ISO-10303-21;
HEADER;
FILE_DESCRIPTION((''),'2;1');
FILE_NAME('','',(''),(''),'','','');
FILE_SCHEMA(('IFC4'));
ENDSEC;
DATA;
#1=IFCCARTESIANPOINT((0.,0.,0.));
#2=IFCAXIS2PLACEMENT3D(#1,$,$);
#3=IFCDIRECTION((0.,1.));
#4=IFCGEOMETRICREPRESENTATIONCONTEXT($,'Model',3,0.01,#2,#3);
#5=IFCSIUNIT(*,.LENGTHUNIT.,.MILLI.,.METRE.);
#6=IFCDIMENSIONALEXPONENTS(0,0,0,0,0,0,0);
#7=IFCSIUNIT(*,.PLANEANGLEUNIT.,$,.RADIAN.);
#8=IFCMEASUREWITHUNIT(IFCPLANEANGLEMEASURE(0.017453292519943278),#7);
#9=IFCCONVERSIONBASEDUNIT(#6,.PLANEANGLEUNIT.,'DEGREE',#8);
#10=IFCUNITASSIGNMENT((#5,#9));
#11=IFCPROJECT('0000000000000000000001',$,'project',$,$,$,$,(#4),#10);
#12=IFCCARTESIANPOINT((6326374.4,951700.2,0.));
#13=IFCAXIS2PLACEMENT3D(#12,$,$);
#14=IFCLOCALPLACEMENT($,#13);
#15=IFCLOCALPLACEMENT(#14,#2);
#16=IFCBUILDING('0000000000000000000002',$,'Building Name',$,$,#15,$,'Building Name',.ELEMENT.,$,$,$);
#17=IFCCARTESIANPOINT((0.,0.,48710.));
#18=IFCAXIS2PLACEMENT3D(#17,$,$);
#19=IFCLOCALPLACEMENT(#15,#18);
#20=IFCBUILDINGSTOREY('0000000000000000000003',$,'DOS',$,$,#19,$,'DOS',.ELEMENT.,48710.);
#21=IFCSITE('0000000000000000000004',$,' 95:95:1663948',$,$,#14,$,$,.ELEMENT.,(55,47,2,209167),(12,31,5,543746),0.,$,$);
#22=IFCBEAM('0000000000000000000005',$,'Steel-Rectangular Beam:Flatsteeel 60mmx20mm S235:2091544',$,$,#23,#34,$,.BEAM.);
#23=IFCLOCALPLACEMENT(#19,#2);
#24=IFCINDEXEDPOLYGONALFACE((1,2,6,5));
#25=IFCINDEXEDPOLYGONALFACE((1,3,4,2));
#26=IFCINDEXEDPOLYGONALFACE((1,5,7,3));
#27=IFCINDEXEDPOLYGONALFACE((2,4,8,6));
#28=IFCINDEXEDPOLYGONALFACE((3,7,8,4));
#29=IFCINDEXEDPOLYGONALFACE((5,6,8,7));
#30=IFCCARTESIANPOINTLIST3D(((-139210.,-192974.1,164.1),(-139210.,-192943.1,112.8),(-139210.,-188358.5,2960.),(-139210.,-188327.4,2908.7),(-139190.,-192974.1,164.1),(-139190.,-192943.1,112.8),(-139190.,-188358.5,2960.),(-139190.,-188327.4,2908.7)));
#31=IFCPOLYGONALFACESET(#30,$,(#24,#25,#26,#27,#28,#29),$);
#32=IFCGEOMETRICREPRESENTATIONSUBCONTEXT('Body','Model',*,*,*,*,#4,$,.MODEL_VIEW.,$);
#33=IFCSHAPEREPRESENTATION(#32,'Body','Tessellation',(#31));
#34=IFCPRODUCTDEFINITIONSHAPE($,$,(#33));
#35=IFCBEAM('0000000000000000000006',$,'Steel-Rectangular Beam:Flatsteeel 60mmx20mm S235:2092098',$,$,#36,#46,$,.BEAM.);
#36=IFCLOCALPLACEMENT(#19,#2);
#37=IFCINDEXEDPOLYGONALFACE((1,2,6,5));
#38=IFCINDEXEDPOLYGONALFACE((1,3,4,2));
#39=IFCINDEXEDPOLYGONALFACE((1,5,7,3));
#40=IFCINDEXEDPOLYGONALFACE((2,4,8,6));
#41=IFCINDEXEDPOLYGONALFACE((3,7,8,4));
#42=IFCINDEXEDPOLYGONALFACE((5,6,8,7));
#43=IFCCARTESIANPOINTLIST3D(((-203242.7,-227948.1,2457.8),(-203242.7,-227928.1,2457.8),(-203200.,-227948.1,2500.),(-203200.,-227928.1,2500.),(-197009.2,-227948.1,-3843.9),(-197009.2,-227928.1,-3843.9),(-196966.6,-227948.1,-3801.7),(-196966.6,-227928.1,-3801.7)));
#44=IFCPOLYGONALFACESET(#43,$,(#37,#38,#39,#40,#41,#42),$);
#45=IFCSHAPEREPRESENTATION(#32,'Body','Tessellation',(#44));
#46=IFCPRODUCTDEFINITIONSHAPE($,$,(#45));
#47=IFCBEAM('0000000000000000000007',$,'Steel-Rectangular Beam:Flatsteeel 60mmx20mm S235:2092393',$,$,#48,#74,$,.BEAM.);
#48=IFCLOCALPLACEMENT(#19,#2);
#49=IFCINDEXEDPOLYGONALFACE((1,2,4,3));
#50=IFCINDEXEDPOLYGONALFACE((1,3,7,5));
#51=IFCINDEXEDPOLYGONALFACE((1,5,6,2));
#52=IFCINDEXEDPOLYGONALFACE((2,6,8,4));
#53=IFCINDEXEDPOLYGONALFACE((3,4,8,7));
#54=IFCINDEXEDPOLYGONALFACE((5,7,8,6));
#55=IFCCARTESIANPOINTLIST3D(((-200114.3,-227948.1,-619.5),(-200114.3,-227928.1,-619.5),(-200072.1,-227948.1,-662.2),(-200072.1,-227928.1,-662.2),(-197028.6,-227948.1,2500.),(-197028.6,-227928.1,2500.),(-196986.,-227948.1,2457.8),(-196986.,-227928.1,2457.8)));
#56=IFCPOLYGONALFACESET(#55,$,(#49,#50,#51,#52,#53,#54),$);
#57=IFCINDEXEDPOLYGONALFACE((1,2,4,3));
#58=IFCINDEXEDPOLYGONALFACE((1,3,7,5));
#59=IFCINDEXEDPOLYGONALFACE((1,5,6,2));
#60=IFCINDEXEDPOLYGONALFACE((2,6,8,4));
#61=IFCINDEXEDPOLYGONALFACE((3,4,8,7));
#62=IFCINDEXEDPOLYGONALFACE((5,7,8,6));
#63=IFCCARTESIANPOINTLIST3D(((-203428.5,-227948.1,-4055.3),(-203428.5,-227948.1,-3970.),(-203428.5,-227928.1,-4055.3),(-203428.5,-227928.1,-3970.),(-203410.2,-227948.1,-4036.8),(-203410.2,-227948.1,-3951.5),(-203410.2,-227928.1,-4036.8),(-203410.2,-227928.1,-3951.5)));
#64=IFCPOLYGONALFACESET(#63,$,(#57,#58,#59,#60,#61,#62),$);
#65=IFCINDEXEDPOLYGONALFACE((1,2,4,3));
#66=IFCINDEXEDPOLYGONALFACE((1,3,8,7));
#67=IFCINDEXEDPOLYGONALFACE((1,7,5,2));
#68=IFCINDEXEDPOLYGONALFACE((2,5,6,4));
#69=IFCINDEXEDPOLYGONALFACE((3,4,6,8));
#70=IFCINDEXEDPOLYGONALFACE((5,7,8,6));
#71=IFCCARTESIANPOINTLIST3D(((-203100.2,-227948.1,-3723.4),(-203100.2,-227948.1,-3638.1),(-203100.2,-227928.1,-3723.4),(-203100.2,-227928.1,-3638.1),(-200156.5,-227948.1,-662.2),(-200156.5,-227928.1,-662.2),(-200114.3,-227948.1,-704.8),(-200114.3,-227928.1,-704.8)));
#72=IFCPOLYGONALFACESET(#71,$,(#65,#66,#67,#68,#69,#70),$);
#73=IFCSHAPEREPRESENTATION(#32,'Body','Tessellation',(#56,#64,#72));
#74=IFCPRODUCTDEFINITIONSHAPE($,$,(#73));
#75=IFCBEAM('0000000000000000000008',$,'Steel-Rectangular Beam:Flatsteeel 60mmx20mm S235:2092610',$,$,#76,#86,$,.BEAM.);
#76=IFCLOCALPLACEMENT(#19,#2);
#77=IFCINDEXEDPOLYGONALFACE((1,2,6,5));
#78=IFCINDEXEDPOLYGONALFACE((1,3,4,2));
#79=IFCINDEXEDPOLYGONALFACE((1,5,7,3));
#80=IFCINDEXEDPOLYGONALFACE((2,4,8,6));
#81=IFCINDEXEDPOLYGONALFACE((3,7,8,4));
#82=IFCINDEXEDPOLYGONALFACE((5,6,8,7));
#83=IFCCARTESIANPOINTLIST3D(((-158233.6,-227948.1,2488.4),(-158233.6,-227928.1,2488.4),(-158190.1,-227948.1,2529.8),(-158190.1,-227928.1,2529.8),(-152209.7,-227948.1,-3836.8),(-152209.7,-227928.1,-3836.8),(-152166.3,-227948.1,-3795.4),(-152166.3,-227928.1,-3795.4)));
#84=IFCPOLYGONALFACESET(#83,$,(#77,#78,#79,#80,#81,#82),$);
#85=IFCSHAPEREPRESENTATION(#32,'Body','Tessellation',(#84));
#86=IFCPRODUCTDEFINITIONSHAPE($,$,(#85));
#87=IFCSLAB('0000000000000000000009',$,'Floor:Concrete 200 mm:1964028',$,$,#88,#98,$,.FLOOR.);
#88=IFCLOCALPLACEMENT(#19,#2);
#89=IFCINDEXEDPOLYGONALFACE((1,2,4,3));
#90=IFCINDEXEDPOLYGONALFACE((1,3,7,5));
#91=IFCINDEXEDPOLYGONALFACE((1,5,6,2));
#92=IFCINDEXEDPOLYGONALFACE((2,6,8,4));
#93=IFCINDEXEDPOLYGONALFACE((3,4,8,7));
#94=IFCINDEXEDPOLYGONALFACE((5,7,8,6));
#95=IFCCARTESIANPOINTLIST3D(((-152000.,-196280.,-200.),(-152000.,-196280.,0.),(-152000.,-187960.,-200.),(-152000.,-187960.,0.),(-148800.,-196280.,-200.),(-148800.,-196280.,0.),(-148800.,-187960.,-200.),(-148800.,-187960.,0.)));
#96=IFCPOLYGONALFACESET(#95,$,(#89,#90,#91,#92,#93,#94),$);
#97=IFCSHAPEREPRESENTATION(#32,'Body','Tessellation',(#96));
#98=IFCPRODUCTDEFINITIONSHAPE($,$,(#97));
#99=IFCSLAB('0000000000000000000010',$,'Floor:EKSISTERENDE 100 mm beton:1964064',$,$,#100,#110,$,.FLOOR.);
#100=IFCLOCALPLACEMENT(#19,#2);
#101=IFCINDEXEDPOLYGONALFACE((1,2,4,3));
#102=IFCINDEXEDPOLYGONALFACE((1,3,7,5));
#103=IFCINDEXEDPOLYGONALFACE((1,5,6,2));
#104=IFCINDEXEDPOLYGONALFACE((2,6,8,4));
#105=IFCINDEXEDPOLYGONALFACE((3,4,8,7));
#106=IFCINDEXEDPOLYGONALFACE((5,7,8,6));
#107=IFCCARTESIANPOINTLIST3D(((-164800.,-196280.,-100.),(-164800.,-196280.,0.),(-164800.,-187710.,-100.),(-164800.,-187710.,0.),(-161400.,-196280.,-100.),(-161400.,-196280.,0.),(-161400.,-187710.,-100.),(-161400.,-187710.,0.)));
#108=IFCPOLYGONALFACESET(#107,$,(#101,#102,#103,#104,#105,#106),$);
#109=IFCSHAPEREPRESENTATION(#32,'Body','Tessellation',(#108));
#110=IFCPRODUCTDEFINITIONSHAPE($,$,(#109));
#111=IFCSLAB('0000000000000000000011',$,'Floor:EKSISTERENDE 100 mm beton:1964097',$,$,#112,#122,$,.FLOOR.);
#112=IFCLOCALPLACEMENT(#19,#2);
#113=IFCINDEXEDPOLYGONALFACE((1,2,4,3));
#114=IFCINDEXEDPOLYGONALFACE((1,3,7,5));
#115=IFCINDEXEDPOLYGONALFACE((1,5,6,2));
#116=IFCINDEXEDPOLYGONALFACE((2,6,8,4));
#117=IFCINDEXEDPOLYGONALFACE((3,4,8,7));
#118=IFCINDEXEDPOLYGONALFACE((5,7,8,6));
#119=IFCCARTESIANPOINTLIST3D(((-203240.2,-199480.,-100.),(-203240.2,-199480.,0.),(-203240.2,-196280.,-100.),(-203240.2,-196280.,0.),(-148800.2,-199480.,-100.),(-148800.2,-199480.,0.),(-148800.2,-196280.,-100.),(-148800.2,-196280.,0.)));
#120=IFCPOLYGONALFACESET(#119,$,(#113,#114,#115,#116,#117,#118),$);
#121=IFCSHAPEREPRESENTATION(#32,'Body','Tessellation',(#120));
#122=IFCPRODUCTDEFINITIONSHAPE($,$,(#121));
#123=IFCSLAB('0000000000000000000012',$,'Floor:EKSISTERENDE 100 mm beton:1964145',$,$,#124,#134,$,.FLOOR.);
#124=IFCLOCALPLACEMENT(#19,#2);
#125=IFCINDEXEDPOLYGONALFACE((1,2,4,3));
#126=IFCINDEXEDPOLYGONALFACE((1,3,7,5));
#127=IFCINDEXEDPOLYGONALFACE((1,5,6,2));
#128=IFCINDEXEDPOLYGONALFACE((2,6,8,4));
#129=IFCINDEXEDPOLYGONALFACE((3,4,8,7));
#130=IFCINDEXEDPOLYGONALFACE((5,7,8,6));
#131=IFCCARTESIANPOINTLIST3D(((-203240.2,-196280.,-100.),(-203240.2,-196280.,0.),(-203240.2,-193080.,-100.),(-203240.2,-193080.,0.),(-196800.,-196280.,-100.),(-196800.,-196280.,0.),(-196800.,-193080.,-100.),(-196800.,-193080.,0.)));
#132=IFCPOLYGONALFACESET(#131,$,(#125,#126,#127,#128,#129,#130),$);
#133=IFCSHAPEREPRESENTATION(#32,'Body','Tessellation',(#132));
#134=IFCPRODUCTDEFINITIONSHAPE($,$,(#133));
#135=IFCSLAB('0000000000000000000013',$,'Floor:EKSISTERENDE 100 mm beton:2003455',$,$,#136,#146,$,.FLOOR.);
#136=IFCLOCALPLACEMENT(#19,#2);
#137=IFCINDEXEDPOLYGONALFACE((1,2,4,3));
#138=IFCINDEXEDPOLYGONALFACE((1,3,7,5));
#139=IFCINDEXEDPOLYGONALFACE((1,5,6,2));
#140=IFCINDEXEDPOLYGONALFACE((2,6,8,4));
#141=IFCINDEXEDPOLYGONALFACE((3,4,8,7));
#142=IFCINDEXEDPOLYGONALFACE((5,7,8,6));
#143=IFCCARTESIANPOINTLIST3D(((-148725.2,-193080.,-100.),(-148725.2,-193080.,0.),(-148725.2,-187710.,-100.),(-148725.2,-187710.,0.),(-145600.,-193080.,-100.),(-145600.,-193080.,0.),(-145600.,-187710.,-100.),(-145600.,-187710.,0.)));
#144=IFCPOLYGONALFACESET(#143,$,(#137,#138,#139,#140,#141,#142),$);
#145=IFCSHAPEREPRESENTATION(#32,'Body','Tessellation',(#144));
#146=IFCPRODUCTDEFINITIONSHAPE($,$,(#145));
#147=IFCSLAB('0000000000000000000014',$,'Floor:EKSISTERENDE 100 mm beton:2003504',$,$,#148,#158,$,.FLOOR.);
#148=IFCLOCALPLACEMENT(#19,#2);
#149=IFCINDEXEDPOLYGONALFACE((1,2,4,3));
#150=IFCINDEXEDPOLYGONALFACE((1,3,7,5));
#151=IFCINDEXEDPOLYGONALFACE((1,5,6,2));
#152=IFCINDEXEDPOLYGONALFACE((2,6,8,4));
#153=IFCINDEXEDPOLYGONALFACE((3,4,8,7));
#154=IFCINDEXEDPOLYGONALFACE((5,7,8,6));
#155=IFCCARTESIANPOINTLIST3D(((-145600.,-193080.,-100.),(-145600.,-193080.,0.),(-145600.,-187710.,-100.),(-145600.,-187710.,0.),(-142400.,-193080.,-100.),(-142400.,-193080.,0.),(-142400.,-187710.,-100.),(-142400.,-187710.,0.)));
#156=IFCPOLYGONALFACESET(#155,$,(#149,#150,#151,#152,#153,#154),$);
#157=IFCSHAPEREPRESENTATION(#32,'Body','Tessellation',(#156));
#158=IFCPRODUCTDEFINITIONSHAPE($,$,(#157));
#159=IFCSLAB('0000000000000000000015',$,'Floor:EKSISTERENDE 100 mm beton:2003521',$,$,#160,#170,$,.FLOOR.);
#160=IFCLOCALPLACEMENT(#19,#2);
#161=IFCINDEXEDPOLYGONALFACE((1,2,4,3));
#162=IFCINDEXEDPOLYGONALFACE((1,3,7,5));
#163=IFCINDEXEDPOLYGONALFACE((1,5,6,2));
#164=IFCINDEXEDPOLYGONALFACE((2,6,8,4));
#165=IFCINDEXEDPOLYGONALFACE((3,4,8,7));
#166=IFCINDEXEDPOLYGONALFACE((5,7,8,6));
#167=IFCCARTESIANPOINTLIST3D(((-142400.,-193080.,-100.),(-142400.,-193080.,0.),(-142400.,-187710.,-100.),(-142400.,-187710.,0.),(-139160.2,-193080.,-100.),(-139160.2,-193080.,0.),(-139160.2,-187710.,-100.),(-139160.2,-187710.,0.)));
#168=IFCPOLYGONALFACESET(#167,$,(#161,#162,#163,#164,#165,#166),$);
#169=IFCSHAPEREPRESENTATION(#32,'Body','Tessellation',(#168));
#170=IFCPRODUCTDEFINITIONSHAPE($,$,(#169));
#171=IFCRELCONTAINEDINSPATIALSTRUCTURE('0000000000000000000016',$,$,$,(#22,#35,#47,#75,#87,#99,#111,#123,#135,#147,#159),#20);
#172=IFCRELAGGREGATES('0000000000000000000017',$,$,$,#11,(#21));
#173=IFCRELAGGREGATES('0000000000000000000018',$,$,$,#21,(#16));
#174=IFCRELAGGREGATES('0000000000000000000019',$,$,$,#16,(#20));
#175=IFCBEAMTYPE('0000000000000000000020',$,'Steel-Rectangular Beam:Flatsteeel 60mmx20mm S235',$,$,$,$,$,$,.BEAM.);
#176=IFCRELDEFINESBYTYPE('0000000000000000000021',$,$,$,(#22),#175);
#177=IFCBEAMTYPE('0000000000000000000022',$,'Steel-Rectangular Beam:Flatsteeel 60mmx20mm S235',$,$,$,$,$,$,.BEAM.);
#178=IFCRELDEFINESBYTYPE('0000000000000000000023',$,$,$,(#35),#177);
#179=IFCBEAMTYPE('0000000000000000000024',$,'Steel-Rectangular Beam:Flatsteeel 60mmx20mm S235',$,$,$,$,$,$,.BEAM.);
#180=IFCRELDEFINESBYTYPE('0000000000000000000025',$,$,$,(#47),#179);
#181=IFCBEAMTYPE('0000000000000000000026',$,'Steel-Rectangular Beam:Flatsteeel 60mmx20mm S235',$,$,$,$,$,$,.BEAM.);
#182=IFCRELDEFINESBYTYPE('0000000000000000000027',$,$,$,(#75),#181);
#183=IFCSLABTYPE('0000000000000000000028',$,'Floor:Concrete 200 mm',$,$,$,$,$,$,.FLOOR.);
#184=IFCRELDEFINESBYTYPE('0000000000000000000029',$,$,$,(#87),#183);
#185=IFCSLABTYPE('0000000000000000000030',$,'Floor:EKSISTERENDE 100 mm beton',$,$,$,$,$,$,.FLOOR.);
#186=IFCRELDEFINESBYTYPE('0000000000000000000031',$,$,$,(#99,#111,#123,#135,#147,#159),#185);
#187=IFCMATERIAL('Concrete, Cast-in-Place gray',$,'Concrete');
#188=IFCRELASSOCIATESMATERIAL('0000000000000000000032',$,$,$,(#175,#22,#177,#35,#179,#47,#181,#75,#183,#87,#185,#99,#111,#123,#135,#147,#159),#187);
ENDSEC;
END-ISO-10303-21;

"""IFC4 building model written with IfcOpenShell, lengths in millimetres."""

from ifc_helpers import new_model, entity, si_unit, converted_unit, direction, frame, origin, place, context, subcontext, project, spatial, indexed_curve, outline, extrude, source, transform, mapped, material, type_object, type_shapes, element, save


model = new_model("IFC4")

# Units and contexts
model_context = context("Model", 3, precision=0.01, world=origin(), true_north=direction((0.0, 1.0)))
body_context = subcontext(model_context, "Body", "Model", "MODEL_VIEW")
ifc_project = project(units=[si_unit("LENGTHUNIT", "METRE", prefix="MILLI"), converted_unit("PLANEANGLEUNIT", "DEGREE", entity("IfcPlaneAngleMeasure", 0.017453292519943278), si_unit("PLANEANGLEUNIT", "RADIAN"), dimensions=[0, 0, 0, 0, 0, 0, 0])], contexts=[model_context])

# Site, building, storey
site_placement = place(None, frame((6326374.4, 951700.2, 0.0)))
site = spatial("IfcSite", under=ifc_project, at=site_placement, Name=" 95:95:1663948", CompositionType="ELEMENT", RefLatitude=(55, 47, 2, 209167), RefLongitude=(12, 31, 5, 543746), RefElevation=0.0)
building_placement = place(site_placement, origin())
building = spatial("IfcBuilding", under=site, at=building_placement, Name="Building Name", LongName="Building Name", CompositionType="ELEMENT")
storey_placement = place(building_placement, frame((0.0, 0.0, 48710.0)))
storey = spatial("IfcBuildingStorey", under=building, at=storey_placement, Name="DOS", LongName="DOS", CompositionType="ELEMENT", Elevation=48710.0)

# Beams
ifc_material = material(Name="Concrete, Cast-in-Place gray", Category="Concrete")
beam_type_1 = type_object("IfcBeamType", Name="Steel-Rectangular Beam:Flatsteeel 60mmx20mm S235", PredefinedType="BEAM", material=ifc_material)
shared_shape_1 = source(origin(), body_context, "Body", "SweptSolid", [
    extrude(outline(indexed_curve([(-30.0, -10.0), (30.0, -10.0), (30.0, 10.0), (-30.0, 10.0), (-30.0, -10.0)], self_intersect=False)), frame((-139200.0, -188342.9, 51644.3), z_axis=(0.0, -0.85532, -0.5181), x_axis=(0.0, 0.5181, -0.85532)), (0.0, 0.0, 1.0), 5396.4),
])
type_shapes(beam_type_1, [shared_shape_1])
beam_1_placement = place(storey_placement, frame((0.0, 0.0, -48710.0)))
element("IfcBeam", 1, at=beam_1_placement, inside=storey, type_object=beam_type_1, material=ifc_material, Name="Steel-Rectangular Beam:Flatsteeel 60mmx20mm S235:2091544", PredefinedType="BEAM", context=body_context, shape_type="MappedRepresentation", body=[
    mapped(shared_shape_1, transform((0.0, 0.0, 0.0), scale=1.0)),
])
beam_type_2 = type_object("IfcBeamType", Name="Steel-Rectangular Beam:Flatsteeel 60mmx20mm S235", PredefinedType="BEAM", material=ifc_material)
shared_shape_2 = source(origin(), body_context, "Body", "SweptSolid", [
    extrude(outline(indexed_curve([(-10.0, -30.0), (10.0, -30.0), (10.0, 30.0), (-10.0, 30.0), (-10.0, -30.0)], self_intersect=False)), frame((-196987.9, -227938.1, 44887.2), z_axis=(-0.703242, 0.0, 0.71095), x_axis=(0.0, -1.0, 0.0)), (0.0, 0.0, 1.0), 8863.8),
])
type_shapes(beam_type_2, [shared_shape_2])
beam_2_placement = place(storey_placement, frame((0.0, 0.0, -48710.0)))
element("IfcBeam", 2, at=beam_2_placement, inside=storey, type_object=beam_type_2, material=ifc_material, Name="Steel-Rectangular Beam:Flatsteeel 60mmx20mm S235:2092098", PredefinedType="BEAM", context=body_context, shape_type="MappedRepresentation", body=[
    mapped(shared_shape_2, transform((0.0, 0.0, 0.0), scale=1.0)),
])
beam_type_3 = type_object("IfcBeamType", Name="Steel-Rectangular Beam:Flatsteeel 60mmx20mm S235", PredefinedType="BEAM", material=ifc_material)
shared_shape_3 = source(origin(), body_context, "Body", "SweptSolid", [
    extrude(outline(indexed_curve([(-2194.1, -30.0), (2194.4, -30.0), (2193.7, 30.0), (-2194.1, 30.0), (-2194.1, -30.0)], self_intersect=False)), frame((-198550.2, -227948.1, 49629.0), z_axis=(0.0, 1.0, 0.0), x_axis=(-0.703242, 0.0, -0.71095)), (0.0, 0.0, 1.0), 20.0),
    extrude(outline(indexed_curve([(17.3, -30.0), (43.4, -30.0), (-17.3, 30.0), (-43.4, 30.0), (17.3, -30.0)], self_intersect=False)), frame((-203419.3, -227948.1, 44706.6), z_axis=(0.0, 1.0, 0.0), x_axis=(0.703242, 0.0, 0.71095)), (0.0, 0.0, 1.0), 20.0),
    extrude(outline(indexed_curve([(-2107.6, -30.0), (2138.2, -30.0), (2077.6, 30.0), (-2108.2, 30.0), (-2107.6, -30.0)], self_intersect=False)), frame((-201617.8, -227948.1, 46527.9), z_axis=(0.0, 1.0, 0.0), x_axis=(-0.703242, 0.0, -0.71095)), (0.0, 0.0, 1.0), 20.0),
])
type_shapes(beam_type_3, [shared_shape_3])
beam_3_placement = place(storey_placement, frame((0.0, 0.0, -48710.0)))
element("IfcBeam", 3, at=beam_3_placement, inside=storey, type_object=beam_type_3, material=ifc_material, Name="Steel-Rectangular Beam:Flatsteeel 60mmx20mm S235:2092393", PredefinedType="BEAM", context=body_context, shape_type="MappedRepresentation", body=[
    mapped(shared_shape_3, transform((0.0, 0.0, 0.0), scale=1.0)),
])
beam_type_4 = type_object("IfcBeamType", Name="Steel-Rectangular Beam:Flatsteeel 60mmx20mm S235", PredefinedType="BEAM", material=ifc_material)
shared_shape_4 = source(origin(), body_context, "Body", "SweptSolid", [
    extrude(outline(indexed_curve([(-10.0, -30.0), (10.0, -30.0), (10.0, 30.0), (-10.0, 30.0), (-10.0, -30.0)], self_intersect=False)), frame((-152188.0, -227938.1, 44893.9), z_axis=(-0.689647, 0.0, 0.724146), x_axis=(0.0, -1.0, 0.0)), (0.0, 0.0, 1.0), 8734.7),
])
type_shapes(beam_type_4, [shared_shape_4])
beam_4_placement = place(storey_placement, frame((0.0, 0.0, -48710.0)))
element("IfcBeam", 4, at=beam_4_placement, inside=storey, type_object=beam_type_4, material=ifc_material, Name="Steel-Rectangular Beam:Flatsteeel 60mmx20mm S235:2092610", PredefinedType="BEAM", context=body_context, shape_type="MappedRepresentation", body=[
    mapped(shared_shape_4, transform((0.0, 0.0, 0.0), scale=1.0)),
])

# Slabs
slab_type_1 = type_object("IfcSlabType", Name="Floor:Concrete 200 mm", PredefinedType="FLOOR", material=ifc_material)
slab_1_placement = place(storey_placement, origin())
element("IfcSlab", 5, at=slab_1_placement, inside=storey, type_object=slab_type_1, material=ifc_material, Name="Floor:Concrete 200 mm:1964028", PredefinedType="FLOOR", context=body_context, shape_type="SweptSolid", body=[
    extrude(outline(indexed_curve([(-4160.0, -1600.0), (4160.0, -1600.0), (4160.0, 1600.0), (-4160.0, 1600.0), (-4160.0, -1600.0)], self_intersect=False)), frame((-150400.0, -192120.0, 0.0), z_axis=(0.0, 0.0, -1.0), x_axis=(0.0, 1.0, 0.0)), (0.0, 0.0, 1.0), 200.0),
])
slab_type_2 = type_object("IfcSlabType", Name="Floor:EKSISTERENDE 100 mm beton", PredefinedType="FLOOR", material=ifc_material)
slab_2_placement = place(storey_placement, origin())
element("IfcSlab", 6, at=slab_2_placement, inside=storey, type_object=slab_type_2, material=ifc_material, Name="Floor:EKSISTERENDE 100 mm beton:1964064", PredefinedType="FLOOR", context=body_context, shape_type="SweptSolid", body=[
    extrude(outline(indexed_curve([(-4285.0, -1700.0), (4285.0, -1700.0), (4285.0, 1700.0), (-4285.0, 1700.0), (-4285.0, -1700.0)], self_intersect=False)), frame((-163100.0, -191995.0, 0.0), z_axis=(0.0, 0.0, -1.0), x_axis=(0.0, 1.0, 0.0)), (0.0, 0.0, 1.0), 100.0),
])
slab_3_placement = place(storey_placement, origin())
element("IfcSlab", 7, at=slab_3_placement, inside=storey, type_object=slab_type_2, material=ifc_material, Name="Floor:EKSISTERENDE 100 mm beton:1964097", PredefinedType="FLOOR", context=body_context, shape_type="SweptSolid", body=[
    extrude(outline(indexed_curve([(-1600.0, -27220.0), (1600.0, -27220.0), (1600.0, 27220.0), (-1600.0, 27220.0), (-1600.0, -27220.0)], self_intersect=False)), frame((-176020.2, -197880.0, 0.0), z_axis=(0.0, 0.0, -1.0), x_axis=(0.0, 1.0, 0.0)), (0.0, 0.0, 1.0), 100.0),
])
slab_4_placement = place(storey_placement, origin())
element("IfcSlab", 8, at=slab_4_placement, inside=storey, type_object=slab_type_2, material=ifc_material, Name="Floor:EKSISTERENDE 100 mm beton:1964145", PredefinedType="FLOOR", context=body_context, shape_type="SweptSolid", body=[
    extrude(outline(indexed_curve([(-1600.0, -3220.1), (1600.0, -3220.1), (1600.0, 3220.1), (-1600.0, 3220.1), (-1600.0, -3220.1)], self_intersect=False)), frame((-200020.1, -194680.0, 0.0), z_axis=(0.0, 0.0, -1.0), x_axis=(0.0, 1.0, 0.0)), (0.0, 0.0, 1.0), 100.0),
])
slab_5_placement = place(storey_placement, origin())
element("IfcSlab", 9, at=slab_5_placement, inside=storey, type_object=slab_type_2, material=ifc_material, Name="Floor:EKSISTERENDE 100 mm beton:2003455", PredefinedType="FLOOR", context=body_context, shape_type="SweptSolid", body=[
    extrude(outline(indexed_curve([(-2685.0, -1562.6), (2685.0, -1562.6), (2685.0, 1562.6), (-2685.0, 1562.6), (-2685.0, -1562.6)], self_intersect=False)), frame((-147162.6, -190395.0, 0.0), z_axis=(0.0, 0.0, -1.0), x_axis=(0.0, 1.0, 0.0)), (0.0, 0.0, 1.0), 100.0),
])
slab_6_placement = place(storey_placement, origin())
element("IfcSlab", 10, at=slab_6_placement, inside=storey, type_object=slab_type_2, material=ifc_material, Name="Floor:EKSISTERENDE 100 mm beton:2003504", PredefinedType="FLOOR", context=body_context, shape_type="SweptSolid", body=[
    extrude(outline(indexed_curve([(-2685.0, -1600.0), (2685.0, -1600.0), (2685.0, 1600.0), (-2685.0, 1600.0), (-2685.0, -1600.0)], self_intersect=False)), frame((-144000.0, -190395.0, 0.0), z_axis=(0.0, 0.0, -1.0), x_axis=(0.0, 1.0, 0.0)), (0.0, 0.0, 1.0), 100.0),
])
slab_7_placement = place(storey_placement, origin())
element("IfcSlab", 11, at=slab_7_placement, inside=storey, type_object=slab_type_2, material=ifc_material, Name="Floor:EKSISTERENDE 100 mm beton:2003521", PredefinedType="FLOOR", context=body_context, shape_type="SweptSolid", body=[
    extrude(outline(indexed_curve([(-2685.0, -1619.9), (2685.0, -1619.9), (2685.0, 1619.9), (-2685.0, 1619.9), (-2685.0, -1619.9)], self_intersect=False)), frame((-140780.1, -190395.0, 0.0), z_axis=(0.0, 0.0, -1.0), x_axis=(0.0, 1.0, 0.0)), (0.0, 0.0, 1.0), 100.0),
])

save(model, "model.ifc")
